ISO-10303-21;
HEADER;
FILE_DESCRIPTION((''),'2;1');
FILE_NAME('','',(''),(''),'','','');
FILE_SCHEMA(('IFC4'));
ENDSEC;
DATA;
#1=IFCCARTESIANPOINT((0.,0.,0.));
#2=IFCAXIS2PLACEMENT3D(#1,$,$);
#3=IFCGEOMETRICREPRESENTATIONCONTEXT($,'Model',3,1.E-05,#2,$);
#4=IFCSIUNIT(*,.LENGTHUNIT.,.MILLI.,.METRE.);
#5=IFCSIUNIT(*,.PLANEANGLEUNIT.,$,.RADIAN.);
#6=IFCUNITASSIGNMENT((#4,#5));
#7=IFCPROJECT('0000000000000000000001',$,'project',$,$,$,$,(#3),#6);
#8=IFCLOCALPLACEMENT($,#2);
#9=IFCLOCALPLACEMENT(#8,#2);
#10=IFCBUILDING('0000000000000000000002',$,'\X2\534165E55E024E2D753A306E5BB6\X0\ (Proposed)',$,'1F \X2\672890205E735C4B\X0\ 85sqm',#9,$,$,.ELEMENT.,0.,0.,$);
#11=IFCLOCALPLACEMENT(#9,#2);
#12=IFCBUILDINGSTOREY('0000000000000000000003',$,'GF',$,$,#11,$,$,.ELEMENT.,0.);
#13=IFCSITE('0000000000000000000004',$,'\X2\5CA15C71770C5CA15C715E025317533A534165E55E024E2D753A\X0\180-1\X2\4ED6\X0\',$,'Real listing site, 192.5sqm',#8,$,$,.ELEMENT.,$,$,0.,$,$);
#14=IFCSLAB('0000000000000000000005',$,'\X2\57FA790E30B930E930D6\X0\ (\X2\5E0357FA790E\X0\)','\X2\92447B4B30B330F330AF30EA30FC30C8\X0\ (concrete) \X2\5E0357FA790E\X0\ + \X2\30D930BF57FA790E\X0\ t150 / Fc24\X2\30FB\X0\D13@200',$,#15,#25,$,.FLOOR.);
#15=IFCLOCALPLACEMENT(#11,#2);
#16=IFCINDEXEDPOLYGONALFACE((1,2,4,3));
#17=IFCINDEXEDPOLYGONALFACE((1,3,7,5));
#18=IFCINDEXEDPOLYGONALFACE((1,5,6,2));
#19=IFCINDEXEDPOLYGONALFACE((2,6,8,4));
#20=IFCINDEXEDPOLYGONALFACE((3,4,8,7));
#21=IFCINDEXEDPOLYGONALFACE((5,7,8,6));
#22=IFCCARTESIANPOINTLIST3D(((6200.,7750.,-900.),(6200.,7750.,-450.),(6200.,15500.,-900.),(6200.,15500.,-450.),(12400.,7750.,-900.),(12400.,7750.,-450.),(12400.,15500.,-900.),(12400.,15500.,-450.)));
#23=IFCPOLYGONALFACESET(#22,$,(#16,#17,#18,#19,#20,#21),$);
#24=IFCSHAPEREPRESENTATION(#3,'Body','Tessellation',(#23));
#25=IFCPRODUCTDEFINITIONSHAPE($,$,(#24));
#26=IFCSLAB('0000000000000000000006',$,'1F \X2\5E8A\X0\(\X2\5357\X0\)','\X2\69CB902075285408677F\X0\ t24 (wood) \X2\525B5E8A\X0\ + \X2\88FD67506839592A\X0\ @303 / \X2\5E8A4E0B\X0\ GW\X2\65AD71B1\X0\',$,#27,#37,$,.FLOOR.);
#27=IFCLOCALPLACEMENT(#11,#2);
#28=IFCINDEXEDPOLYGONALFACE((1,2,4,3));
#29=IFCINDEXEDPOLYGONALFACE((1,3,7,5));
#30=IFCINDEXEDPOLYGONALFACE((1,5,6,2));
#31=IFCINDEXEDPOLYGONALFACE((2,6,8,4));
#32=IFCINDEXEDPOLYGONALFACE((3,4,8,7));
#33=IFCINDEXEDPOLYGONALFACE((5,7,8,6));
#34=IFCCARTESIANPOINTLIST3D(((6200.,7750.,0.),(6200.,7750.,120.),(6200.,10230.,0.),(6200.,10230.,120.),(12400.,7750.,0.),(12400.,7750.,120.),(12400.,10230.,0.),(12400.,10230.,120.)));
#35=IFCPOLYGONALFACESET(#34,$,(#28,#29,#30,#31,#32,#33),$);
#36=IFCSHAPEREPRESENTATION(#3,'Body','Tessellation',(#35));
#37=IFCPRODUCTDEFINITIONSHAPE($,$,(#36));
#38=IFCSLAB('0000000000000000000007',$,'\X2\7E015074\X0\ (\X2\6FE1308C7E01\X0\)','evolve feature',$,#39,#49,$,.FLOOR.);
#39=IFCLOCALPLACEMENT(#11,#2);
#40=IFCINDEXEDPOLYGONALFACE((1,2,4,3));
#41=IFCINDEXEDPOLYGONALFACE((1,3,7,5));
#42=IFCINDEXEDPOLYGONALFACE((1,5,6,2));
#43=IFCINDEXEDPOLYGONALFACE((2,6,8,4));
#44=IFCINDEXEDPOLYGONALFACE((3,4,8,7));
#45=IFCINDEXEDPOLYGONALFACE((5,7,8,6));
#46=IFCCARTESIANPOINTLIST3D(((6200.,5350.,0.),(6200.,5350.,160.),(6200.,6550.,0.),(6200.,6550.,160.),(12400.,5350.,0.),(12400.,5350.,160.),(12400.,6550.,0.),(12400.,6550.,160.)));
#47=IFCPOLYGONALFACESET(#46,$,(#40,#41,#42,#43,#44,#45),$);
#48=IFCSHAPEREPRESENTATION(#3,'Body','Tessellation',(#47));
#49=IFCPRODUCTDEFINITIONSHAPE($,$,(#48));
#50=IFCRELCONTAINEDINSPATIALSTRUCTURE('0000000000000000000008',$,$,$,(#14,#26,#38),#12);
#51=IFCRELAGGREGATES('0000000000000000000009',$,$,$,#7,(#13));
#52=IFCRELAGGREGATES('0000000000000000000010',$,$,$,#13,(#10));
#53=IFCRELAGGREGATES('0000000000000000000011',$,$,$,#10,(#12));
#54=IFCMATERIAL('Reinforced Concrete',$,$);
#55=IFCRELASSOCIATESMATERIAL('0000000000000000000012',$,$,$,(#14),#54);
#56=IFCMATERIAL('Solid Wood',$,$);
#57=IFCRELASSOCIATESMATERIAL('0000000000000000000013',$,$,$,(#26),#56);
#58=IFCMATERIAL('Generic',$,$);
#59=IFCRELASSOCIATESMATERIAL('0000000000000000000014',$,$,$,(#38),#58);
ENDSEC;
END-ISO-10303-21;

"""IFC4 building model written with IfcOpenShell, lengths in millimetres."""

from ifc_helpers import new_model, si_unit, frame, frame_2d, origin, place, context, project, spatial, rectangle, extrude, material, element, save


model = new_model("IFC4")

# Units and contexts
model_context = context("Model", 3, precision=1e-05, world=origin())
ifc_project = project(units=[si_unit("LENGTHUNIT", "METRE", prefix="MILLI"), si_unit("PLANEANGLEUNIT", "RADIAN")], contexts=[model_context])

# Site, building, storey
site_placement = place(None, origin())
site = spatial("IfcSite", under=ifc_project, at=site_placement, Name="岡山県岡山市北区十日市中町180-1他", ObjectType="Real listing site, 192.5sqm", CompositionType="ELEMENT", RefElevation=0.0)
building_placement = place(site_placement, origin())
building = spatial("IfcBuilding", under=site, at=building_placement, Name="十日市中町の家 (Proposed)", ObjectType="1F 木造平屋 85sqm", CompositionType="ELEMENT", ElevationOfRefHeight=0.0, ElevationOfTerrain=0.0)
storey_placement = place(building_placement, origin())
storey = spatial("IfcBuildingStorey", under=building, at=storey_placement, Name="GF", CompositionType="ELEMENT", Elevation=0.0)

# Slabs
ifc_material_1 = material(Name="Reinforced Concrete")
slab_1_placement = place(storey_placement, frame((3100.0, 3875.0, -450.0)))
element("IfcSlab", 1, at=slab_1_placement, inside=storey, material=ifc_material_1, Name="基礎スラブ (布基礎)", Description="鉄筋コンクリート (concrete) 布基礎 + ベタ基礎 t150 / Fc24・D13@200", PredefinedType="FLOOR", context=model_context, shape_type="SweptSolid", body=[
    extrude(rectangle(XDim=6200.0, YDim=7750.0, at=frame_2d((3100.0, 3875.0))), frame((3100.0, 3875.0, -450.0)), (0.0, 0.0, 1.0), 450.0),
])
ifc_material_2 = material(Name="Solid Wood")
slab_2_placement = place(storey_placement, frame((3100.0, 3875.0, 0.0)))
element("IfcSlab", 2, at=slab_2_placement, inside=storey, material=ifc_material_2, Name="1F 床(南)", Description="構造用合板 t24 (wood) 剛床 + 製材根太 @303 / 床下 GW断熱", PredefinedType="FLOOR", context=model_context, shape_type="SweptSolid", body=[
    extrude(rectangle(XDim=6200.0, YDim=2480.0, at=frame_2d((3100.0, 1240.0))), frame((3100.0, 3875.0, 0.0)), (0.0, 0.0, 1.0), 120.0),
])
ifc_material_3 = material(Name="Generic")
slab_3_placement = place(storey_placement, frame((3100.0, 2675.0, 0.0)))
element("IfcSlab", 3, at=slab_3_placement, inside=storey, material=ifc_material_3, Name="縁側 (濡れ縁)", Description="evolve feature", PredefinedType="FLOOR", context=model_context, shape_type="SweptSolid", body=[
    extrude(rectangle(XDim=6200.0, YDim=1200.0, at=frame_2d((3100.0, 600.0))), frame((3100.0, 2675.0, 0.0)), (0.0, 0.0, 1.0), 160.0),
])

save(model, "model.ifc")
